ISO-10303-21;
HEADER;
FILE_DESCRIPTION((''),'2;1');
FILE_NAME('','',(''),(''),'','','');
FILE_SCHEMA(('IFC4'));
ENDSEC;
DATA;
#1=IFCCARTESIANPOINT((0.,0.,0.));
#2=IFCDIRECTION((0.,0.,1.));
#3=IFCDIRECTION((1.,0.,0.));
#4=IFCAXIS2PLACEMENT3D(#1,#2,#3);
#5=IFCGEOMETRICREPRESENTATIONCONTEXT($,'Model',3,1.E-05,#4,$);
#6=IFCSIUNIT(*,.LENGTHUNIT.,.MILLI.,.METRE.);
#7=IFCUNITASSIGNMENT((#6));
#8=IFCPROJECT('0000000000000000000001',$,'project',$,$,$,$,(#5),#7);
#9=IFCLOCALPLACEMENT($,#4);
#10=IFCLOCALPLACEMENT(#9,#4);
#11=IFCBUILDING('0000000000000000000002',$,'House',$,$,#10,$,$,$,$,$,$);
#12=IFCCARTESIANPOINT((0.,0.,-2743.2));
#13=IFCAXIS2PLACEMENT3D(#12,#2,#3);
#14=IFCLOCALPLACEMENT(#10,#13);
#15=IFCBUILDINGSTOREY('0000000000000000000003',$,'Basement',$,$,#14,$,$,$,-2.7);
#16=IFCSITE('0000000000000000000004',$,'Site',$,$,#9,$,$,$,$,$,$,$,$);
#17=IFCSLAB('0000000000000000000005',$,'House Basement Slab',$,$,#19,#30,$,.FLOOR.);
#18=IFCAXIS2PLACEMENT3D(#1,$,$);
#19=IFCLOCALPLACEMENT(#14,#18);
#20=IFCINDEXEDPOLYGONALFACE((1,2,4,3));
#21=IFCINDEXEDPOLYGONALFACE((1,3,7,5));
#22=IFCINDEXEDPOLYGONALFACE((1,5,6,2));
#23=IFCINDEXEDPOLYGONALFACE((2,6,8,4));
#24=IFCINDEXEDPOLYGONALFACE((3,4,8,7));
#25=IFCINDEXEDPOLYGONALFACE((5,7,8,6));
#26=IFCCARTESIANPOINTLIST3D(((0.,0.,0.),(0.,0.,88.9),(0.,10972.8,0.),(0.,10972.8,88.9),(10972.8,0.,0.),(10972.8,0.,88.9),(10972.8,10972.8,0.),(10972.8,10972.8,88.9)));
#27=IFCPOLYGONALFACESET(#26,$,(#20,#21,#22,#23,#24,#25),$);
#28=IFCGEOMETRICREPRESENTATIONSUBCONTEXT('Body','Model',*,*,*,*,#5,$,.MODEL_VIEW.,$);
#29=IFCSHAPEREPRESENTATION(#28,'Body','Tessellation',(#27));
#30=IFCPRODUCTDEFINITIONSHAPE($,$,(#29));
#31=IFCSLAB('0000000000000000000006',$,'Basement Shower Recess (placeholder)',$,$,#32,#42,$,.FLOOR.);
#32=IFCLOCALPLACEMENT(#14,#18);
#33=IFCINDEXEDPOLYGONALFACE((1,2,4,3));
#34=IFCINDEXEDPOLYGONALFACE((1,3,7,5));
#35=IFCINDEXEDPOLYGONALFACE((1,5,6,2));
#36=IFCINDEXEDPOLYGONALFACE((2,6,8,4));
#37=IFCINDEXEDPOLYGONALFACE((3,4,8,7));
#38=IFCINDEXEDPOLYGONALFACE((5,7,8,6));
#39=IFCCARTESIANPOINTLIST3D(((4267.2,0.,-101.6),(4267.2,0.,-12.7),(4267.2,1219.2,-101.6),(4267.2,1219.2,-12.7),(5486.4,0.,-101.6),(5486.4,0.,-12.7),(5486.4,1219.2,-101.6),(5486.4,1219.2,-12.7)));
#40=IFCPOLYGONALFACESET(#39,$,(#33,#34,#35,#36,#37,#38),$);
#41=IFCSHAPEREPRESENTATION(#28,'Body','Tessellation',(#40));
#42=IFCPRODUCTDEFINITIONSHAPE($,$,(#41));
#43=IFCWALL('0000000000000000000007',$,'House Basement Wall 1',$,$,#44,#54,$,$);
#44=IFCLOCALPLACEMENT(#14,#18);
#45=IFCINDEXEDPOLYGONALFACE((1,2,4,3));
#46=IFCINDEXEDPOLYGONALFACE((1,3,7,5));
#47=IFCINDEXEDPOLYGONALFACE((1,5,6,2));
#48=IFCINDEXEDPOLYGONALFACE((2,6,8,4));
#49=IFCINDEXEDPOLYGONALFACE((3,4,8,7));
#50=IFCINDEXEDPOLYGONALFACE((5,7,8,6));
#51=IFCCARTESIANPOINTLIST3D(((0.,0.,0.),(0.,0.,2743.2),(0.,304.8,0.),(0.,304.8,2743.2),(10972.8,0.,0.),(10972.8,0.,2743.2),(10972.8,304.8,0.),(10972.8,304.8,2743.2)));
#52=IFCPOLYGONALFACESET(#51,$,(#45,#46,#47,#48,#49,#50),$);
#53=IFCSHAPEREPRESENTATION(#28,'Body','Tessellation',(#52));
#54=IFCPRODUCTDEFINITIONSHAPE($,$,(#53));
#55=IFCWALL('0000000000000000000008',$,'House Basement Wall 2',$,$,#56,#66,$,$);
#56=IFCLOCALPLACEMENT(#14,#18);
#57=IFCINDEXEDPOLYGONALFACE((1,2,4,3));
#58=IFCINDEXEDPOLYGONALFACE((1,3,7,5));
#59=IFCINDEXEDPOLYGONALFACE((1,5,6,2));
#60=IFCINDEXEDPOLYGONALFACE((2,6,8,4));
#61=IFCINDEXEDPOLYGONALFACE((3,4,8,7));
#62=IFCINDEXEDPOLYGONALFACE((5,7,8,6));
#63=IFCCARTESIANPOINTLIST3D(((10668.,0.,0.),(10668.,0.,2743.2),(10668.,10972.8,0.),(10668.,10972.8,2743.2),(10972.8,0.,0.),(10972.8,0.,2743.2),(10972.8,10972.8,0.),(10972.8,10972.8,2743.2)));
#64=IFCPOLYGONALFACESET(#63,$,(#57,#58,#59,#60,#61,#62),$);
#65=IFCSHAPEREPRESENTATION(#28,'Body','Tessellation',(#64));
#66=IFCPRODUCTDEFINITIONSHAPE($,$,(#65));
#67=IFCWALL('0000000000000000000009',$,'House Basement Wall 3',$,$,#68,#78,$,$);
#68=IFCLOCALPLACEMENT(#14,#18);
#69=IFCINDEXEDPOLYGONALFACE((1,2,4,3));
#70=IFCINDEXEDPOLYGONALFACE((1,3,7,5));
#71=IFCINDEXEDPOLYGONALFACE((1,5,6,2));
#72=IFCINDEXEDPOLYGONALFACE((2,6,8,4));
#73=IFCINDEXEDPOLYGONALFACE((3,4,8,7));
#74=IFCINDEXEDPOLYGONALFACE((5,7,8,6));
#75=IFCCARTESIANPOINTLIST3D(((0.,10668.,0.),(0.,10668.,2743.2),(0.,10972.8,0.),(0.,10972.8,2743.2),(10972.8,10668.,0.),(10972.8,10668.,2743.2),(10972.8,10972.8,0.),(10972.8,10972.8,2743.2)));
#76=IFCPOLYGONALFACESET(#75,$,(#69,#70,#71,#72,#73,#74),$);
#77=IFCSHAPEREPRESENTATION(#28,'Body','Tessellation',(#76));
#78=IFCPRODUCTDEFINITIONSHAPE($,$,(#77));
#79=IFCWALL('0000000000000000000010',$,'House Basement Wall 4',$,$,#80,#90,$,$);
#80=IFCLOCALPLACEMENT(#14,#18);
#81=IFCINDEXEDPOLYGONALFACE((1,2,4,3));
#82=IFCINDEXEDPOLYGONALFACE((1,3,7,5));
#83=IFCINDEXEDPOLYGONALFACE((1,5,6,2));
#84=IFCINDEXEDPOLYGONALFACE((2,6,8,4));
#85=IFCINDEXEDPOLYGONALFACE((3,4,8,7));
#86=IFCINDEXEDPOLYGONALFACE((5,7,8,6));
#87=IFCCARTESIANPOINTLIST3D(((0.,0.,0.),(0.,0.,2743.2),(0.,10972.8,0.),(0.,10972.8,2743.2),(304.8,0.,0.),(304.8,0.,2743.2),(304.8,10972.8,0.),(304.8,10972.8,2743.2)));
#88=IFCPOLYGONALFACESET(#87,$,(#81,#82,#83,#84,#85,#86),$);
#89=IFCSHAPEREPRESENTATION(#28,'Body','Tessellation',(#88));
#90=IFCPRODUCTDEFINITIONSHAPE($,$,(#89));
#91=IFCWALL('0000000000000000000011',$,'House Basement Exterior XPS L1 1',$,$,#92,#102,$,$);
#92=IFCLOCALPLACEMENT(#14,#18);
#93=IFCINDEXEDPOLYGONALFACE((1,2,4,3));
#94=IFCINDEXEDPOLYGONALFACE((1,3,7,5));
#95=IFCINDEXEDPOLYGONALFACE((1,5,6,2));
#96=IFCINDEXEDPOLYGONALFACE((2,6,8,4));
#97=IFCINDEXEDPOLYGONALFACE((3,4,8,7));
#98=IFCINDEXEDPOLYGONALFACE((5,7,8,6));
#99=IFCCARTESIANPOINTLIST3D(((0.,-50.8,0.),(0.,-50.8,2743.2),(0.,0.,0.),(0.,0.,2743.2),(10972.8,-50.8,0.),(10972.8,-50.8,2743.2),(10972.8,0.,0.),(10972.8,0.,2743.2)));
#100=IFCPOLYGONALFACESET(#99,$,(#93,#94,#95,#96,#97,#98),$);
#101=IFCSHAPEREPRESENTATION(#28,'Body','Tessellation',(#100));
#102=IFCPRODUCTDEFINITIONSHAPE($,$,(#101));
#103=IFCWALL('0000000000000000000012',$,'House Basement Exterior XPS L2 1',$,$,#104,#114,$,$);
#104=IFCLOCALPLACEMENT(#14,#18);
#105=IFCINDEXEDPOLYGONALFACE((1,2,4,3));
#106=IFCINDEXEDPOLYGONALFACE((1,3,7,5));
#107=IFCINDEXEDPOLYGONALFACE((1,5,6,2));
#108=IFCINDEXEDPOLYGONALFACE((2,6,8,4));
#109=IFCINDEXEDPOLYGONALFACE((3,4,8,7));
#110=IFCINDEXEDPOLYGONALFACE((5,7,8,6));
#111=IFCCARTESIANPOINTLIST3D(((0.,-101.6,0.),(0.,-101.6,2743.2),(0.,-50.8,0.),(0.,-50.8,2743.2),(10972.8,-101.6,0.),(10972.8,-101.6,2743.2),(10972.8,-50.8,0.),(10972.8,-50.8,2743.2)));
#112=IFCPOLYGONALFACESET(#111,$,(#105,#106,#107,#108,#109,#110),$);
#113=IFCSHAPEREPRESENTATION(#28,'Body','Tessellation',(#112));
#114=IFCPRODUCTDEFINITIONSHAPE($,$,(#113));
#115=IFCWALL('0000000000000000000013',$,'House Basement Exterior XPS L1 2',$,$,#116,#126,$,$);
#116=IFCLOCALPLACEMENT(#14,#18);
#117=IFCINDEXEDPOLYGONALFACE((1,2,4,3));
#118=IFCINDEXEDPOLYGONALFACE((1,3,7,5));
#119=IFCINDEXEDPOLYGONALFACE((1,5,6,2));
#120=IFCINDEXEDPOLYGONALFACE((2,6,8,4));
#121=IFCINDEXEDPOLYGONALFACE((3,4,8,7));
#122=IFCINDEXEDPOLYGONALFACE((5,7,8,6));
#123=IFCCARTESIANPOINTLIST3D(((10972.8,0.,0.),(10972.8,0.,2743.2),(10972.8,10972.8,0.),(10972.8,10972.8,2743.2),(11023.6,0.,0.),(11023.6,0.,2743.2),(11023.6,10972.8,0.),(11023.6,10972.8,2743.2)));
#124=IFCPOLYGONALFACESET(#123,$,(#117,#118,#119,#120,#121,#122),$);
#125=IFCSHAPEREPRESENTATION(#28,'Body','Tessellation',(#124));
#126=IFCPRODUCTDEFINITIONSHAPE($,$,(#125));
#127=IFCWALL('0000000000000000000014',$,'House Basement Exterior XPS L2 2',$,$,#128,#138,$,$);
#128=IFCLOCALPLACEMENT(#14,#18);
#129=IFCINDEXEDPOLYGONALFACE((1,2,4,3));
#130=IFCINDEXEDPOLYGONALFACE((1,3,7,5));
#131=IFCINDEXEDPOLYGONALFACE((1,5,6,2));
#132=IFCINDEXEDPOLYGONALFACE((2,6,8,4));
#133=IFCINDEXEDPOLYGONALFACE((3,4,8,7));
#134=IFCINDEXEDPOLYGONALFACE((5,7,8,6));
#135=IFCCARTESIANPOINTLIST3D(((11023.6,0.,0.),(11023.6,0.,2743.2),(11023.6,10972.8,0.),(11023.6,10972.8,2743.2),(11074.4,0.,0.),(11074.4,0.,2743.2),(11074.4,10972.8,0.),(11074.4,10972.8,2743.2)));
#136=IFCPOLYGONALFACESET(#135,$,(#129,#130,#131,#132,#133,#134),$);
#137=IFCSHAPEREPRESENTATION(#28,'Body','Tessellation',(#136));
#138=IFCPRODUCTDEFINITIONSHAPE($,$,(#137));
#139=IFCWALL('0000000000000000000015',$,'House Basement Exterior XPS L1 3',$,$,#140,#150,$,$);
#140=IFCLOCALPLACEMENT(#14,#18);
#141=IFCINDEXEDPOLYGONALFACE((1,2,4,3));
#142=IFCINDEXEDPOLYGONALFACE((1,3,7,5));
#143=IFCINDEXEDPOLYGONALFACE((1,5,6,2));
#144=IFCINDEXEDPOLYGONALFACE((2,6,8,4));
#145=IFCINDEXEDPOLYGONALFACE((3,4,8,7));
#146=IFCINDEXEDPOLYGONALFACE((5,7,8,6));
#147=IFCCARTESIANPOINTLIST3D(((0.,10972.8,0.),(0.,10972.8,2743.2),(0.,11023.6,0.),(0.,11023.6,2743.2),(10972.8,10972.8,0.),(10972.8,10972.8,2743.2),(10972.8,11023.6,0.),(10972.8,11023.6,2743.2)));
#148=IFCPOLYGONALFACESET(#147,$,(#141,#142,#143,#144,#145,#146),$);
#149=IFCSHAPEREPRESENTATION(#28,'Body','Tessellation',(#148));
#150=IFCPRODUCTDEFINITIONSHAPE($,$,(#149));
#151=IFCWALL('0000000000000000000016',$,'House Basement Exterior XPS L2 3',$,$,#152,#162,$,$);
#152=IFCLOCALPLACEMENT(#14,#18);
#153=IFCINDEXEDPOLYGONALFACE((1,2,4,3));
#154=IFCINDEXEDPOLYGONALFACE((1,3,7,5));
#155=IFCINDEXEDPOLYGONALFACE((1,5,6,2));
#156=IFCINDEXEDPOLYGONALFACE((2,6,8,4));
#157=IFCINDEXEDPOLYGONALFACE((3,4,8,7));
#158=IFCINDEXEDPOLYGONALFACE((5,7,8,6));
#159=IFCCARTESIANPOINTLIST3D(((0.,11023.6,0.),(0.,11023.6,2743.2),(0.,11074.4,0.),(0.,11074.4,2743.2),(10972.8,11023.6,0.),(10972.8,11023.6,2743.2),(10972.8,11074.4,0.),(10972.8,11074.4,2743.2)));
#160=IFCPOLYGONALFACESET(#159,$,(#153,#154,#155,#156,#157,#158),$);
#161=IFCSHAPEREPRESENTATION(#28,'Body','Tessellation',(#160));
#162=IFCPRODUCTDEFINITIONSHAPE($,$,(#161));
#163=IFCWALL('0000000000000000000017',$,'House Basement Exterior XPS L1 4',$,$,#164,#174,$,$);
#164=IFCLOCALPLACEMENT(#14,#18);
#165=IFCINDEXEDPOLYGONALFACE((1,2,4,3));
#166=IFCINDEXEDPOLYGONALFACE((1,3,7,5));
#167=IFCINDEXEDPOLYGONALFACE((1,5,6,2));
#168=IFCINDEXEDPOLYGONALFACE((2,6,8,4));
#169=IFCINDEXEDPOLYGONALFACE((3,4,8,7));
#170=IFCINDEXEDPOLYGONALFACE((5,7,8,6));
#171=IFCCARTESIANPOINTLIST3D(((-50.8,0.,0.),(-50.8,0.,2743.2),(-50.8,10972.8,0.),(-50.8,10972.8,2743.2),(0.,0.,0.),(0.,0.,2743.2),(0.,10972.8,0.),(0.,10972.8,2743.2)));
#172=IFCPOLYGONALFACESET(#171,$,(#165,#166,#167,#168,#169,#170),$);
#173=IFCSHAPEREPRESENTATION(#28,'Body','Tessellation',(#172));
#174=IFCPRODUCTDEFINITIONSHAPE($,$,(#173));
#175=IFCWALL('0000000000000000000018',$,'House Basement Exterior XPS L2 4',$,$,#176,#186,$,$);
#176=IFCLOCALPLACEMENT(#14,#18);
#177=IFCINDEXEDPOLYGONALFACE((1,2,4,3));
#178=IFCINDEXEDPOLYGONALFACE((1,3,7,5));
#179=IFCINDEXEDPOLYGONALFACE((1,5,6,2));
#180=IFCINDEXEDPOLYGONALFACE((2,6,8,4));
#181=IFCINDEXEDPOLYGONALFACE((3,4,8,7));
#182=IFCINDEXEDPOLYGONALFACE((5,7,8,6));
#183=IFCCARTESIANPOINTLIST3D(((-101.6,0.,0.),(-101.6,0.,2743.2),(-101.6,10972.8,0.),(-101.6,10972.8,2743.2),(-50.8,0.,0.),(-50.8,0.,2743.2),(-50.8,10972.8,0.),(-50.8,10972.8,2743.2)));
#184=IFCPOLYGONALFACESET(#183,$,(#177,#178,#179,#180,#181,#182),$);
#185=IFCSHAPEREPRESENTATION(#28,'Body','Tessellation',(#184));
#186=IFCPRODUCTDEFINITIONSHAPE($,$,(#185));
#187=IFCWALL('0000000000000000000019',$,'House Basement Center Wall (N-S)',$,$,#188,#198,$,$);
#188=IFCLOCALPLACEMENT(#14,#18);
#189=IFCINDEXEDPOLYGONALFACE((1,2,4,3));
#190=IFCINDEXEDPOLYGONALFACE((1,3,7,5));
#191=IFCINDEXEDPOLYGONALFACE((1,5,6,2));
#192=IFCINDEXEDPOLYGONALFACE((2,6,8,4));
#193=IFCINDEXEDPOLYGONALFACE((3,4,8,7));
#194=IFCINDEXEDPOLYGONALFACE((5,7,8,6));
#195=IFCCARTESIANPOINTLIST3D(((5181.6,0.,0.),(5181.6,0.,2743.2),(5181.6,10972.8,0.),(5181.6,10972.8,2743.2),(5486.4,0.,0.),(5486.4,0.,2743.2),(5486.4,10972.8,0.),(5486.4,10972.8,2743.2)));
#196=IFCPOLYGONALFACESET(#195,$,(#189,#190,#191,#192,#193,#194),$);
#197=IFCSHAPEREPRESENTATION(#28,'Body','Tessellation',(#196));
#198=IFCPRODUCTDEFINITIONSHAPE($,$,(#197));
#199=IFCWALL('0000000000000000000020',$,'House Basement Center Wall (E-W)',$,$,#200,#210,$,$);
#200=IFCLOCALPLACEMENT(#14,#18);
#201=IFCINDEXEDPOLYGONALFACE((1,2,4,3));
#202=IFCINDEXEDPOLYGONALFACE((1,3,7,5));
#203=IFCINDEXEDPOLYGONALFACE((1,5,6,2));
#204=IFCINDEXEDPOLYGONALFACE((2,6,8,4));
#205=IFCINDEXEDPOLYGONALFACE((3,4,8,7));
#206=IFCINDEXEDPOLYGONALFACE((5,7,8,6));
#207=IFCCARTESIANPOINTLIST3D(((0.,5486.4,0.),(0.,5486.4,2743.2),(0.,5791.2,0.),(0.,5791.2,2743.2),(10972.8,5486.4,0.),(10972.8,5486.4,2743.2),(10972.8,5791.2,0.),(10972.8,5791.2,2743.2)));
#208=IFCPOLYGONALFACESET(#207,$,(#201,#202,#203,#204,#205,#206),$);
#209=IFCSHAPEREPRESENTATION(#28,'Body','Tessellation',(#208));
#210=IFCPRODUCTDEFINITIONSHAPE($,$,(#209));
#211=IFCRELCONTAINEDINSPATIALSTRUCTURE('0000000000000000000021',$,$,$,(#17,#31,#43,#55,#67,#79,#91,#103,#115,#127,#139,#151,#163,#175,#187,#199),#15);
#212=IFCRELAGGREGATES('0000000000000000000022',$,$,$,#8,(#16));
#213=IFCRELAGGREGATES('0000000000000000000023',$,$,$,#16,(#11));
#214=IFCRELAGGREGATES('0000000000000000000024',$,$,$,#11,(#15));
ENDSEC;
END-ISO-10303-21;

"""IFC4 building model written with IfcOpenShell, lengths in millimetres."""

from ifc_helpers import new_model, si_unit, frame, origin_with_axes, place, context, subcontext, project, spatial, indexed_curve, outline, extrude, element, save


model = new_model("IFC4")

# Units and contexts
model_context = context("Model", 3, precision=1e-05, world=origin_with_axes())
body_context = subcontext(model_context, "Body", "Model", "MODEL_VIEW")
ifc_project = project(units=[si_unit("LENGTHUNIT", "METRE", prefix="MILLI")], contexts=[model_context])

# Site, building, storey
site_placement = place(None, origin_with_axes())
site = spatial("IfcSite", under=ifc_project, at=site_placement, Name="Site")
building_placement = place(site_placement, origin_with_axes())
building = spatial("IfcBuilding", under=site, at=building_placement, Name="House")
storey_placement = place(building_placement, frame((0.0, 0.0, -2743.2), z_axis=(0.0, 0.0, 1.0), x_axis=(1.0, 0.0, 0.0)))
storey = spatial("IfcBuildingStorey", under=building, at=storey_placement, Name="Basement", Elevation=-2.7)

# Slabs
slab_1_placement = place(storey_placement, origin_with_axes())
element("IfcSlab", 1, at=slab_1_placement, inside=storey, Name="House Basement Slab", PredefinedType="FLOOR", context=body_context, shape_type="SweptSolid", body=[
    extrude(outline(indexed_curve([(0.0, 0.0), (10972.8, 0.0), (10972.8, 10972.8), (0.0, 10972.8), (0.0, 0.0)])), None, (0.0, 0.0, 1.0), 88.9),
])
slab_2_placement = place(storey_placement, frame((0.0, 0.0, -101.6), z_axis=(0.0, 0.0, 1.0), x_axis=(1.0, 0.0, 0.0)))
element("IfcSlab", 2, at=slab_2_placement, inside=storey, Name="Basement Shower Recess (placeholder)", PredefinedType="FLOOR", context=body_context, shape_type="SweptSolid", body=[
    extrude(outline(indexed_curve([(4267.2, 0.0), (5486.4, 0.0), (5486.4, 1219.2), (4267.2, 1219.2), (4267.2, 0.0)])), None, (0.0, 0.0, 1.0), 88.9),
])

# Walls
for number, where, z_axis, x_axis, name in (
    (3, (0.0, 0.0, 0.0), (0.0, 0.0, 1.0), (1.0, 0.0, 0.0), "House Basement Wall 1"),
    (4, (10972.8, 0.0, 0.0), (0.0, 0.0, 1.0), (0.0, 1.0, 0.0), "House Basement Wall 2"),
    (5, (10972.8, 10972.8, 0.0), (0.0, 0.0, 1.0), (-1.0, 0.0, 0.0), "House Basement Wall 3"),
    (6, (0.0, 10972.8, 0.0), (0.0, 0.0, 1.0), (0.0, -1.0, 0.0), "House Basement Wall 4"),
):
    element("IfcWall", number, at=place(storey_placement, frame(where, z_axis=z_axis, x_axis=x_axis)), inside=storey, Name=name, context=body_context, shape_type="SweptSolid", body=[
        extrude(outline(indexed_curve([(0.0, 0.0), (0.0, 304.8), (10972.8, 304.8), (10972.8, 0.0), (0.0, 0.0)], self_intersect=False)), origin_with_axes(), (0.0, 0.0, 1.0), 2743.2),
    ])
wall_1_placement = place(storey_placement, origin_with_axes())
element("IfcWall", 7, at=wall_1_placement, inside=storey, Name="House Basement Exterior XPS L1 1", context=body_context, shape_type="SweptSolid", body=[
    extrude(outline(indexed_curve([(0.0, 0.0), (0.0, -50.8), (10972.8, -50.8), (10972.8, 0.0), (0.0, 0.0)], self_intersect=False)), origin_with_axes(), (0.0, 0.0, 1.0), 2743.2),
])
wall_2_placement = place(storey_placement, origin_with_axes())
element("IfcWall", 8, at=wall_2_placement, inside=storey, Name="House Basement Exterior XPS L2 1", context=body_context, shape_type="SweptSolid", body=[
    extrude(outline(indexed_curve([(0.0, 0.0), (0.0, -50.8), (10972.8, -50.8), (10972.8, 0.0), (0.0, 0.0)], self_intersect=False)), frame((0.0, -50.8, 0.0), z_axis=(0.0, 0.0, 1.0), x_axis=(1.0, 0.0, 0.0)), (0.0, 0.0, 1.0), 2743.2),
])
wall_3_placement = place(storey_placement, frame((10972.8, 0.0, 0.0), z_axis=(0.0, 0.0, 1.0), x_axis=(0.0, 1.0, 0.0)))
element("IfcWall", 9, at=wall_3_placement, inside=storey, Name="House Basement Exterior XPS L1 2", context=body_context, shape_type="SweptSolid", body=[
    extrude(outline(indexed_curve([(0.0, 0.0), (0.0, -50.8), (10972.8, -50.8), (10972.8, 0.0), (0.0, 0.0)], self_intersect=False)), origin_with_axes(), (0.0, 0.0, 1.0), 2743.2),
])
wall_4_placement = place(storey_placement, frame((10972.8, 0.0, 0.0), z_axis=(0.0, 0.0, 1.0), x_axis=(0.0, 1.0, 0.0)))
element("IfcWall", 10, at=wall_4_placement, inside=storey, Name="House Basement Exterior XPS L2 2", context=body_context, shape_type="SweptSolid", body=[
    extrude(outline(indexed_curve([(0.0, 0.0), (0.0, -50.8), (10972.8, -50.8), (10972.8, 0.0), (0.0, 0.0)], self_intersect=False)), frame((0.0, -50.8, 0.0), z_axis=(0.0, 0.0, 1.0), x_axis=(1.0, 0.0, 0.0)), (0.0, 0.0, 1.0), 2743.2),
])
wall_5_placement = place(storey_placement, frame((10972.8, 10972.8, 0.0), z_axis=(0.0, 0.0, 1.0), x_axis=(-1.0, 0.0, 0.0)))
element("IfcWall", 11, at=wall_5_placement, inside=storey, Name="House Basement Exterior XPS L1 3", context=body_context, shape_type="SweptSolid", body=[
    extrude(outline(indexed_curve([(0.0, 0.0), (0.0, -50.8), (10972.8, -50.8), (10972.8, 0.0), (0.0, 0.0)], self_intersect=False)), origin_with_axes(), (0.0, 0.0, 1.0), 2743.2),
])
wall_6_placement = place(storey_placement, frame((10972.8, 10972.8, 0.0), z_axis=(0.0, 0.0, 1.0), x_axis=(-1.0, 0.0, 0.0)))
element("IfcWall", 12, at=wall_6_placement, inside=storey, Name="House Basement Exterior XPS L2 3", context=body_context, shape_type="SweptSolid", body=[
    extrude(outline(indexed_curve([(0.0, 0.0), (0.0, -50.8), (10972.8, -50.8), (10972.8, 0.0), (0.0, 0.0)], self_intersect=False)), frame((0.0, -50.8, 0.0), z_axis=(0.0, 0.0, 1.0), x_axis=(1.0, 0.0, 0.0)), (0.0, 0.0, 1.0), 2743.2),
])
wall_7_placement = place(storey_placement, frame((0.0, 10972.8, 0.0), z_axis=(0.0, 0.0, 1.0), x_axis=(0.0, -1.0, 0.0)))
element("IfcWall", 13, at=wall_7_placement, inside=storey, Name="House Basement Exterior XPS L1 4", context=body_context, shape_type="SweptSolid", body=[
    extrude(outline(indexed_curve([(0.0, 0.0), (0.0, -50.8), (10972.8, -50.8), (10972.8, 0.0), (0.0, 0.0)], self_intersect=False)), origin_with_axes(), (0.0, 0.0, 1.0), 2743.2),
])
wall_8_placement = place(storey_placement, frame((0.0, 10972.8, 0.0), z_axis=(0.0, 0.0, 1.0), x_axis=(0.0, -1.0, 0.0)))
element("IfcWall", 14, at=wall_8_placement, inside=storey, Name="House Basement Exterior XPS L2 4", context=body_context, shape_type="SweptSolid", body=[
    extrude(outline(indexed_curve([(0.0, 0.0), (0.0, -50.8), (10972.8, -50.8), (10972.8, 0.0), (0.0, 0.0)], self_intersect=False)), frame((0.0, -50.8, 0.0), z_axis=(0.0, 0.0, 1.0), x_axis=(1.0, 0.0, 0.0)), (0.0, 0.0, 1.0), 2743.2),
])
for number, where, z_axis, x_axis, name in (
    (15, (5486.4, 0.0, 0.0), (0.0, 0.0, 1.0), (0.0, 1.0, 0.0), "House Basement Center Wall (N-S)"),
    (16, (0.0, 5486.4, 0.0), (0.0, 0.0, 1.0), (1.0, 0.0, 0.0), "House Basement Center Wall (E-W)"),
):
    element("IfcWall", number, at=place(storey_placement, frame(where, z_axis=z_axis, x_axis=x_axis)), inside=storey, Name=name, context=body_context, shape_type="SweptSolid", body=[
        extrude(outline(indexed_curve([(0.0, 0.0), (0.0, 304.8), (10972.8, 304.8), (10972.8, 0.0), (0.0, 0.0)], self_intersect=False)), origin_with_axes(), (0.0, 0.0, 1.0), 2743.2),
    ])

save(model, "model.ifc")
